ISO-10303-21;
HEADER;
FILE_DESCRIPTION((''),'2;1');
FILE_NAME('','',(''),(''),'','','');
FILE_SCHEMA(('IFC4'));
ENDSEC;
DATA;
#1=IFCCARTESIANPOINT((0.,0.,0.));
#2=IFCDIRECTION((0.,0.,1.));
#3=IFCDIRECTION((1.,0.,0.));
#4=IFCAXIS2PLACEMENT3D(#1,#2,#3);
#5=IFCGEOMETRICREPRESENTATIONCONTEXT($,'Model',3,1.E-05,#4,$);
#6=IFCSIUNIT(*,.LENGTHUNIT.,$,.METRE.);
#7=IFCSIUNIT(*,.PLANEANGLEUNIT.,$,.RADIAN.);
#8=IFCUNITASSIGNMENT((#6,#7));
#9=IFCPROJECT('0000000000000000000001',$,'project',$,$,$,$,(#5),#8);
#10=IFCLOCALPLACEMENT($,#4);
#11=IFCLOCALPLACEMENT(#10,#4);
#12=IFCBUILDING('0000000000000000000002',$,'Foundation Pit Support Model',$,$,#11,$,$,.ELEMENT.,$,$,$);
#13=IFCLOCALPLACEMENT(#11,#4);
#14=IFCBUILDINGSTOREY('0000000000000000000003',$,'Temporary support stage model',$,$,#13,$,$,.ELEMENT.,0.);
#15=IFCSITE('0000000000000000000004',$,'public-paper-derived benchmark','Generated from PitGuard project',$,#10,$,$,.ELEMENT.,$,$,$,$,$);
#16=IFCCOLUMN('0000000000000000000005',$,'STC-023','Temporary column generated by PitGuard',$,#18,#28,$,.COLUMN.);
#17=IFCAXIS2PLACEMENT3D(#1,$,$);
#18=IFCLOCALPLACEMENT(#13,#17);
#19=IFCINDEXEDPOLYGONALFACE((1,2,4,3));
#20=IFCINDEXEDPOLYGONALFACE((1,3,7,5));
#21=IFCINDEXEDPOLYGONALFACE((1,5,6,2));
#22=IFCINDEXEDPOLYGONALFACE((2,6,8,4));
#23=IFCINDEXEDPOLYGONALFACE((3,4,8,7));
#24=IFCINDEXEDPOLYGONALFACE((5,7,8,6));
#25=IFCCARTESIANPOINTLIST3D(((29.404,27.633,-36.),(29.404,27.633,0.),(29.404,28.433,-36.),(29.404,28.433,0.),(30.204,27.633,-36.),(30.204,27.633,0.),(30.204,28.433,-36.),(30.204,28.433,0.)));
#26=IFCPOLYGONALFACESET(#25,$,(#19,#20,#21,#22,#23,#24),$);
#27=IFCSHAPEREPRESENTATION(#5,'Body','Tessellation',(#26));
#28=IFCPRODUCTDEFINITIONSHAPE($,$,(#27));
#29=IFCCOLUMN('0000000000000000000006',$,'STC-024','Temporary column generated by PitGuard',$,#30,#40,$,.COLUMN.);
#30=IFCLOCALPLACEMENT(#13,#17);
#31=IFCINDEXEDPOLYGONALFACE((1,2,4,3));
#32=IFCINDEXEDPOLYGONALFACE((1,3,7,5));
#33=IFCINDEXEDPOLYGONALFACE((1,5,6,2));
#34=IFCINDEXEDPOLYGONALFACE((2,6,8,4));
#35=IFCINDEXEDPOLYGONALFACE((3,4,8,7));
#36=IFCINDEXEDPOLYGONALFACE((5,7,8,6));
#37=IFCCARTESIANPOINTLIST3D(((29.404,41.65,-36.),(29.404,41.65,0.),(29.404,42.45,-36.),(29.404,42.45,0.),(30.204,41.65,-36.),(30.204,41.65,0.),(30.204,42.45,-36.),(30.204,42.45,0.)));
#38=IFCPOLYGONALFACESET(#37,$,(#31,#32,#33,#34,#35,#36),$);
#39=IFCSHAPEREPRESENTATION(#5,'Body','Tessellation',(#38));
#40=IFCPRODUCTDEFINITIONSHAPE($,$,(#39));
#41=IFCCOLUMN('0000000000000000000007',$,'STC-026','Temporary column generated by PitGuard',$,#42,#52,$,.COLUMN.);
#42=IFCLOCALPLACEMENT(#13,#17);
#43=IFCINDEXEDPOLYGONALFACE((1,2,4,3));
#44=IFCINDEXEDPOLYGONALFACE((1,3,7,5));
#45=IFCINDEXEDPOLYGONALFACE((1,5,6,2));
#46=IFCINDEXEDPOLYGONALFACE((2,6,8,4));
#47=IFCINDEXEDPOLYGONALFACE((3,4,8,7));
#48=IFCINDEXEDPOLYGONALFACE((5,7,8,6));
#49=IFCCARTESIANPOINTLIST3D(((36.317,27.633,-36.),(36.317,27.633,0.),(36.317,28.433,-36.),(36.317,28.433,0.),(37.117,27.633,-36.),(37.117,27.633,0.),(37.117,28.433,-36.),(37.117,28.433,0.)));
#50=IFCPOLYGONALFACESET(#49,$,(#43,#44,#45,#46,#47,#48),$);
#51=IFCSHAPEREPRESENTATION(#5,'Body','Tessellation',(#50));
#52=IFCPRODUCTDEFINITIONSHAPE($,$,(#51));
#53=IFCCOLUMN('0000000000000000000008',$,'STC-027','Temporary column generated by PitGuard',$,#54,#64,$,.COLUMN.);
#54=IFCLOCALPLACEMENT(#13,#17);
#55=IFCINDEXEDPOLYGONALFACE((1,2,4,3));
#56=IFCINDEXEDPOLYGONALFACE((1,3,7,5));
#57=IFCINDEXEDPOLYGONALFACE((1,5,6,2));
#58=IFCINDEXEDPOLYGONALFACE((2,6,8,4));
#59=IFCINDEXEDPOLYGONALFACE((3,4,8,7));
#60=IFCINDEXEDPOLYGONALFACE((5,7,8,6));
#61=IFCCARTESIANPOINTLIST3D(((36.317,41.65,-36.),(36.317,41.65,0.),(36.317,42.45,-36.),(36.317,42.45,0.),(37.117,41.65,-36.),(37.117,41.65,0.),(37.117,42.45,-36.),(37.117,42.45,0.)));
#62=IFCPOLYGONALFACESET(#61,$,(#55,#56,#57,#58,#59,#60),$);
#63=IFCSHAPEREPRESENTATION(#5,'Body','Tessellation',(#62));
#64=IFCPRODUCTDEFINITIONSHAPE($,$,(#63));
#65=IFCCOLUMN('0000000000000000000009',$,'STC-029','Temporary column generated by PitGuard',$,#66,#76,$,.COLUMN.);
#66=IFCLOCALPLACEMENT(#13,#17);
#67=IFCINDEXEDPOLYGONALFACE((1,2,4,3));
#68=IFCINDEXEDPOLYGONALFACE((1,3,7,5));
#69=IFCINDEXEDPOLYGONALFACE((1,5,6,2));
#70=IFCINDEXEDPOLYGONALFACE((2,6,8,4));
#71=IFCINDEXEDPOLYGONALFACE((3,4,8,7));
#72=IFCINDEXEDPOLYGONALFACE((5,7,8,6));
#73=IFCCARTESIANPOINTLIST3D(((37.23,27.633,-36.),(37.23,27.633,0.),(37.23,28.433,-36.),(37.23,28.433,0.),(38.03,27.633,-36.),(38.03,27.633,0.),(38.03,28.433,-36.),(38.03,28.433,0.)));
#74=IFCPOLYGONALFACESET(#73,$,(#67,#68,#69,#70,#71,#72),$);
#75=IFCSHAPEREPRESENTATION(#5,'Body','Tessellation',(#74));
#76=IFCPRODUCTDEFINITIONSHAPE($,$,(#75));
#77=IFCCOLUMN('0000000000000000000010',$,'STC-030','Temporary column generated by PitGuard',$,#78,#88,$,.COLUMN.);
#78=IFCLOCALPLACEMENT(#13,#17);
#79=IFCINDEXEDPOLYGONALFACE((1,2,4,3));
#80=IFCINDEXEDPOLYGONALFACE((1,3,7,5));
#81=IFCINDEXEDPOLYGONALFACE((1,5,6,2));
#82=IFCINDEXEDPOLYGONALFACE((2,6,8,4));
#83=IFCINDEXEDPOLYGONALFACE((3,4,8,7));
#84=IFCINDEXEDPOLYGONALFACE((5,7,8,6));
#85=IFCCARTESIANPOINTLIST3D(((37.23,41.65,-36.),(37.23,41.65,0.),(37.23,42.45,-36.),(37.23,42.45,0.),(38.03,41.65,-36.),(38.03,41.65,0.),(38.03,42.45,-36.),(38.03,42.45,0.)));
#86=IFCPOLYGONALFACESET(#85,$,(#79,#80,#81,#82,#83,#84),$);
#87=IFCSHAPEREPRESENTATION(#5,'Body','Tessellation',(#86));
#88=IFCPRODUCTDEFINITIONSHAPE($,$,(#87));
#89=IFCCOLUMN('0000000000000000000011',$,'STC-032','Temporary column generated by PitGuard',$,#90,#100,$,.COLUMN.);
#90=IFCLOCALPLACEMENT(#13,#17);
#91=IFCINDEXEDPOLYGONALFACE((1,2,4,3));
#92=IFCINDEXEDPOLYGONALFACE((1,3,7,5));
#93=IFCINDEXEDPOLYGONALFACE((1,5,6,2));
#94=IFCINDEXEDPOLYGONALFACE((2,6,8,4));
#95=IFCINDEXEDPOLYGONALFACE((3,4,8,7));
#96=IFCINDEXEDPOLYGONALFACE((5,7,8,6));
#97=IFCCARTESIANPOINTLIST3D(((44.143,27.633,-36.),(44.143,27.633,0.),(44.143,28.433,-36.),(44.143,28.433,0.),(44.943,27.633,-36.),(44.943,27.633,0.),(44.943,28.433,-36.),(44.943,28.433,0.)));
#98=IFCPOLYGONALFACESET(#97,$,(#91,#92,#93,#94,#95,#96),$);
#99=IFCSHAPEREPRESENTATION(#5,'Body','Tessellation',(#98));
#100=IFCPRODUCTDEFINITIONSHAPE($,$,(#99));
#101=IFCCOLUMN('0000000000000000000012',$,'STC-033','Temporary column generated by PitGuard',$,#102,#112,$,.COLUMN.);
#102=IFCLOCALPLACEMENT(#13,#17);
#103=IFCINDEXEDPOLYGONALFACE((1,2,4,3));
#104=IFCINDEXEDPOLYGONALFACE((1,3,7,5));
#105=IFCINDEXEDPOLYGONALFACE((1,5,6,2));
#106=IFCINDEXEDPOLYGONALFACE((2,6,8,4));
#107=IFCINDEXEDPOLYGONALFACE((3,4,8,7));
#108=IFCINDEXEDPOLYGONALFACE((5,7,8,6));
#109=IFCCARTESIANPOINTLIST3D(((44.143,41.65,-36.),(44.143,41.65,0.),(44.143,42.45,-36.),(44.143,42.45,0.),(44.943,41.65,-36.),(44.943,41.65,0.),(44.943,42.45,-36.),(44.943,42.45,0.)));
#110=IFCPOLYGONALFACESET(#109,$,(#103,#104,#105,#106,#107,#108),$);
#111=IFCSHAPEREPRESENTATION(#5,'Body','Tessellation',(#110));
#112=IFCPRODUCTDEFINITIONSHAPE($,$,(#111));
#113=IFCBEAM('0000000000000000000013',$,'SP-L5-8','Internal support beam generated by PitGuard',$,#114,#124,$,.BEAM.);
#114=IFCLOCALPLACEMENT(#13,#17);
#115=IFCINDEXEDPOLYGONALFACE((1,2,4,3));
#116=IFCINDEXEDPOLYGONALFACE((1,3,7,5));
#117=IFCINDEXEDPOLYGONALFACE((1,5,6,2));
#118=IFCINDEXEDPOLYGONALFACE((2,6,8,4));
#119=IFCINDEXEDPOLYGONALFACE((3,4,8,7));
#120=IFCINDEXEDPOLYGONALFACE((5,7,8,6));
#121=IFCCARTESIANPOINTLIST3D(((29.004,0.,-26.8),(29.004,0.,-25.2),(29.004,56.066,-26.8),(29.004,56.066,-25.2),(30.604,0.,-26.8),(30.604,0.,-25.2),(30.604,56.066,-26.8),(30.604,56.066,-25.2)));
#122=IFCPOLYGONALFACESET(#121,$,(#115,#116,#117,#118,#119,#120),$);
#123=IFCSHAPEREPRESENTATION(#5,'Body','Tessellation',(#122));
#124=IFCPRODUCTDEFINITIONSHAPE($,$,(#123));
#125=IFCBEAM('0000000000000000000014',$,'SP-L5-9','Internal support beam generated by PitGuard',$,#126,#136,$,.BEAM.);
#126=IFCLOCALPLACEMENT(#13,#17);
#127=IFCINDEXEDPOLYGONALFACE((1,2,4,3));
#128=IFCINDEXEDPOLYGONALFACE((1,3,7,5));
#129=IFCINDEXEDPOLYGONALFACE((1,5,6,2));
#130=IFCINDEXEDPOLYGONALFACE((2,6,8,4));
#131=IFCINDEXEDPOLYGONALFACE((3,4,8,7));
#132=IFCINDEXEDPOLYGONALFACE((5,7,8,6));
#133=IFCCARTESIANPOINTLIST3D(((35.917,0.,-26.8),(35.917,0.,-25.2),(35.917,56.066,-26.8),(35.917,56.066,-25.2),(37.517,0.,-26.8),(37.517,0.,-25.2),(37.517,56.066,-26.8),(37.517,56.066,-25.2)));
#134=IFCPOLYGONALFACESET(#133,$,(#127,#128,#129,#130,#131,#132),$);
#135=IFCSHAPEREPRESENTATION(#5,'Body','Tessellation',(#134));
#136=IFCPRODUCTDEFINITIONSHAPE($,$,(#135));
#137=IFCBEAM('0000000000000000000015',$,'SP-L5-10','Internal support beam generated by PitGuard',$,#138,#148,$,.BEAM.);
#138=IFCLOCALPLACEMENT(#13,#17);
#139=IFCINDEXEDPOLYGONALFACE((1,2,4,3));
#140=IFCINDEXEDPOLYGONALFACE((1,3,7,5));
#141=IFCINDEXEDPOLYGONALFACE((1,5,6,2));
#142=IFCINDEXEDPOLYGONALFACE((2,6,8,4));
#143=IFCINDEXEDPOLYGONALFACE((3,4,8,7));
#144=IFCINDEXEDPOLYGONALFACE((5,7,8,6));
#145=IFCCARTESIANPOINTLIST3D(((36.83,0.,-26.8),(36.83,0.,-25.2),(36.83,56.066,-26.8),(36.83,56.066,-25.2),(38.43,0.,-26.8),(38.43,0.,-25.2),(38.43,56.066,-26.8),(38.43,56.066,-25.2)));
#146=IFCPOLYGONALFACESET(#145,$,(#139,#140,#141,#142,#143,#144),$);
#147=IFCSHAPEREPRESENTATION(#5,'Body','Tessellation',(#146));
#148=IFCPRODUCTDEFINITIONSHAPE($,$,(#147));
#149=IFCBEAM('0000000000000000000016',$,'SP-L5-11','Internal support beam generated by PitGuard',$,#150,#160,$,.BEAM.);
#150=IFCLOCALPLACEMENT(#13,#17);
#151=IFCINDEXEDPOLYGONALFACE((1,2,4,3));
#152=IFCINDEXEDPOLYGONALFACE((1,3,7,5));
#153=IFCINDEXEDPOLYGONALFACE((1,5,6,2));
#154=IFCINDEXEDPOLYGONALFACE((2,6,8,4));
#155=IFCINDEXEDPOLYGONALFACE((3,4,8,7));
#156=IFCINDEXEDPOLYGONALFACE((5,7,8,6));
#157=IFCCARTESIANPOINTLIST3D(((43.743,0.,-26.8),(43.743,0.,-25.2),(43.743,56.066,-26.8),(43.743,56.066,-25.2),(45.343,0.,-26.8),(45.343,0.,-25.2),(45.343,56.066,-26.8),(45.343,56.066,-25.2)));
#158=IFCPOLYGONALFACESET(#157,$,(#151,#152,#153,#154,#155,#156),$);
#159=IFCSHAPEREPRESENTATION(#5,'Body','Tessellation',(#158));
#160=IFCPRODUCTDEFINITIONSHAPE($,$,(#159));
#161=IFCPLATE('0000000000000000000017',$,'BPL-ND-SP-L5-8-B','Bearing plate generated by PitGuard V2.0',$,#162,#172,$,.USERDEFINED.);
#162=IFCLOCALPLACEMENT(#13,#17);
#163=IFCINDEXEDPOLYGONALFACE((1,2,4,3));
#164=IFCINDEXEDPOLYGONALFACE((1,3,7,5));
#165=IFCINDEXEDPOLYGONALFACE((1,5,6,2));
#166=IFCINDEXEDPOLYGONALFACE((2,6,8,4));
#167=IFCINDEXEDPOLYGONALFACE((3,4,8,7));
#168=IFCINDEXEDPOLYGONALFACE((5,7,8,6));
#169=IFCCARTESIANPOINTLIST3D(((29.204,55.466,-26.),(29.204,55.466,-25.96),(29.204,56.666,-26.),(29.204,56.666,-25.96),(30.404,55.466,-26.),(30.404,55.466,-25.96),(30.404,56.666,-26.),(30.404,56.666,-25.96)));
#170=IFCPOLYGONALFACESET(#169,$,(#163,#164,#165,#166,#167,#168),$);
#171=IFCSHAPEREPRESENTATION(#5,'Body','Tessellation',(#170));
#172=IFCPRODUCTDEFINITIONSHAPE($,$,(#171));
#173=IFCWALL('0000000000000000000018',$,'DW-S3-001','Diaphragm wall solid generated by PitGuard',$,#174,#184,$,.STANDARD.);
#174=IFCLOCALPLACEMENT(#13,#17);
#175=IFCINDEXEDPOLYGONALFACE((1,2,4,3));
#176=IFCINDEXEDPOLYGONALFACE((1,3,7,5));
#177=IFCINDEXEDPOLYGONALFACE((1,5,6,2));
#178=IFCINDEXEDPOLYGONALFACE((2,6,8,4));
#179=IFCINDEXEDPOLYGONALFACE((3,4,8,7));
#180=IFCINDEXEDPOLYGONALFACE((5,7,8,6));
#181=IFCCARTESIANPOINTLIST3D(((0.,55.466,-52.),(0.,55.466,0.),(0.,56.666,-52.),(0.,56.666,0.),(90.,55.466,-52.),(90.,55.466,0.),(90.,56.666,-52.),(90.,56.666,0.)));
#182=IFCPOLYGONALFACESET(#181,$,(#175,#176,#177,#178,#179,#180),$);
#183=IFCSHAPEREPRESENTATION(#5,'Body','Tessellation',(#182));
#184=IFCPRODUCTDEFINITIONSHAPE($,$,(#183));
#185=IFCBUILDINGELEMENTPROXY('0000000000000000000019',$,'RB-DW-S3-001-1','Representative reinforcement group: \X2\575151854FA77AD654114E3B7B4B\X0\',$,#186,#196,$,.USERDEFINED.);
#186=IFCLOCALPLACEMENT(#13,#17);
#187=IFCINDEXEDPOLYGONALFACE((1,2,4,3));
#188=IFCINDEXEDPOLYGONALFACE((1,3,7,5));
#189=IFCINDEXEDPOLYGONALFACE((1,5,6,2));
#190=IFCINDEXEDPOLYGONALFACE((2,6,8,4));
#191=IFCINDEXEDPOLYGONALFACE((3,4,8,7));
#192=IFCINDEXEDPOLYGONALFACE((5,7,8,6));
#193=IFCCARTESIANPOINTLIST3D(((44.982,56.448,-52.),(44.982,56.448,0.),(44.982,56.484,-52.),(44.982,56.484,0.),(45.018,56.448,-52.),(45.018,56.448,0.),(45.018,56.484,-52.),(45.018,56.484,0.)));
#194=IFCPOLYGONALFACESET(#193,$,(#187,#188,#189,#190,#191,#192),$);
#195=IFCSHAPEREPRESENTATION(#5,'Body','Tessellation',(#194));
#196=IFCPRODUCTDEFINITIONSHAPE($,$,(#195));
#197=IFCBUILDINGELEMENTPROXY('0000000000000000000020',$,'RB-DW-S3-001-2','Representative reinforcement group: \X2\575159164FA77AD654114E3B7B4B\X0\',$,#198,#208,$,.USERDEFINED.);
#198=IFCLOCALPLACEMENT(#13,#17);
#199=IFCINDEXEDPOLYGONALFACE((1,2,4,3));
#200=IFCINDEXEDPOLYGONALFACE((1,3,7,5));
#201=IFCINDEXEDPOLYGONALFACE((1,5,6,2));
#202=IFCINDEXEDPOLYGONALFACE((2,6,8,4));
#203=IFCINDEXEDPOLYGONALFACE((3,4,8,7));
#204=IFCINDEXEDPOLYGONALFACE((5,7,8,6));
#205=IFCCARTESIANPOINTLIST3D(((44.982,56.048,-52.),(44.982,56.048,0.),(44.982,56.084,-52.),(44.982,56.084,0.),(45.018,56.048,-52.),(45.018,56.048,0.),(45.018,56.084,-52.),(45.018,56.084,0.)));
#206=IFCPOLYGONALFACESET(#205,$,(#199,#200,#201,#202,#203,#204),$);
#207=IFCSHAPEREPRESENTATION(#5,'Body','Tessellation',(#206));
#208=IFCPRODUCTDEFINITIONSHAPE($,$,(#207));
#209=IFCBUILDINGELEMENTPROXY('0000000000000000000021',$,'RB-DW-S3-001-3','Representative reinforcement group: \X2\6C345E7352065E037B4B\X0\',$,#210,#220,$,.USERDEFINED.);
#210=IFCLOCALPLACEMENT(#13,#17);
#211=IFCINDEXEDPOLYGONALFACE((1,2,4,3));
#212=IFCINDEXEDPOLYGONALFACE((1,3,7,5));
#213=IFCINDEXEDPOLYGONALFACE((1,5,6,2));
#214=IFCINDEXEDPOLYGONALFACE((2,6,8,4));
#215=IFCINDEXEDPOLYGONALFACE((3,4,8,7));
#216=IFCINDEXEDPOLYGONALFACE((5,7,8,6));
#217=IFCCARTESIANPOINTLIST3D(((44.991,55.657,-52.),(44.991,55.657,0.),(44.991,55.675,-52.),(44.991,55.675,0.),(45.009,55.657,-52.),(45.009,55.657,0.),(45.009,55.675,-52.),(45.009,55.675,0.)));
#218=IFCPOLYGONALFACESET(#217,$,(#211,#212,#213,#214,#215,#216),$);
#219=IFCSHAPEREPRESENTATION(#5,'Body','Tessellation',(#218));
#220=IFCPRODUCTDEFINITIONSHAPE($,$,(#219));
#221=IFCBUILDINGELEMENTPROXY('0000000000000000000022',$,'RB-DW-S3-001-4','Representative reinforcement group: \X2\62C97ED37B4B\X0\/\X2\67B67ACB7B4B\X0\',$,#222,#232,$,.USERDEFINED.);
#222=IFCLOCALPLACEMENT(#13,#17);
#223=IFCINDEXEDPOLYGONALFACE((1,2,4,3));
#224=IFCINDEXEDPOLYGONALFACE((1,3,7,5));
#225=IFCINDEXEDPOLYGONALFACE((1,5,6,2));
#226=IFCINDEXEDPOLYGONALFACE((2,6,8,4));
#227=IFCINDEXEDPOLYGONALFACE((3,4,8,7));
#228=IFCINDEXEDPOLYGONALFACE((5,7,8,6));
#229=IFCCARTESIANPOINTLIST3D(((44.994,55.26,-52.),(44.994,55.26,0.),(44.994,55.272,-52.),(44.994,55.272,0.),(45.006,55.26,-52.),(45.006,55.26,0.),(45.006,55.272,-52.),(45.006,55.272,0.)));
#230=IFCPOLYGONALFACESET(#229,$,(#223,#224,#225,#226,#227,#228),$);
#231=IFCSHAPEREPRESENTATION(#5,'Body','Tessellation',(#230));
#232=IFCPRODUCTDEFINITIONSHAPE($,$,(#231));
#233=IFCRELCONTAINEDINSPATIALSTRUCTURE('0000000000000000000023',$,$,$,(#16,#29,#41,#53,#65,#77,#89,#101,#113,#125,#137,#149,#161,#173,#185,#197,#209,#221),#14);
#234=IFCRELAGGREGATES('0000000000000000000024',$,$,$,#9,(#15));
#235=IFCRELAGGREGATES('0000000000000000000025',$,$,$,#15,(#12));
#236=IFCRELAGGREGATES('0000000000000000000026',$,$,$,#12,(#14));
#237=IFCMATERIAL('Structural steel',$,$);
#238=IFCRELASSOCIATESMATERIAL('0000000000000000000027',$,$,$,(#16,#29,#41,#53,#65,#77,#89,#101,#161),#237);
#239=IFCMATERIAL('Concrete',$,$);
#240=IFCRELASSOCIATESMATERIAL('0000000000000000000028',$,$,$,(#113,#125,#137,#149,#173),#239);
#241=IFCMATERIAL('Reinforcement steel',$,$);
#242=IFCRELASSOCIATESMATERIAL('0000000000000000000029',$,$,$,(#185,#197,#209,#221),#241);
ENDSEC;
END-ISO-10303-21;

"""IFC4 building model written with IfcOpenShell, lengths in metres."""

from ifc_helpers import new_model, si_unit, frame, origin_with_axes, origin_2d, place, context, project, spatial, rectangle, extrude, material, element, save


model = new_model("IFC4")

# Units and contexts
model_context = context("Model", 3, precision=1e-05, world=origin_with_axes())
ifc_project = project(units=[si_unit("LENGTHUNIT", "METRE"), si_unit("PLANEANGLEUNIT", "RADIAN")], contexts=[model_context])

# Site, building, storey
site_placement = place(None, origin_with_axes())
site = spatial("IfcSite", under=ifc_project, at=site_placement, Name="public-paper-derived benchmark", Description="Generated from PitGuard project", CompositionType="ELEMENT")
building_placement = place(site_placement, origin_with_axes())
building = spatial("IfcBuilding", under=site, at=building_placement, Name="Foundation Pit Support Model", CompositionType="ELEMENT")
storey_placement = place(building_placement, origin_with_axes())
storey = spatial("IfcBuildingStorey", under=building, at=storey_placement, Name="Temporary support stage model", CompositionType="ELEMENT", Elevation=0.0)

# Columns
ifc_material_1 = material(Name="Structural steel")
for number, where, z_axis, x_axis, name in (
    (1, (29.804, 28.033, -36.0), (0.0, 0.0, 1.0), (1.0, 0.0, 0.0), "STC-023"),
    (2, (29.804, 42.05, -36.0), (0.0, 0.0, 1.0), (1.0, 0.0, 0.0), "STC-024"),
    (3, (36.717, 28.033, -36.0), (0.0, 0.0, 1.0), (1.0, 0.0, 0.0), "STC-026"),
    (4, (36.717, 42.05, -36.0), (0.0, 0.0, 1.0), (1.0, 0.0, 0.0), "STC-027"),
    (5, (37.63, 28.033, -36.0), (0.0, 0.0, 1.0), (1.0, 0.0, 0.0), "STC-029"),
    (6, (37.63, 42.05, -36.0), (0.0, 0.0, 1.0), (1.0, 0.0, 0.0), "STC-030"),
    (7, (44.543, 28.033, -36.0), (0.0, 0.0, 1.0), (1.0, 0.0, 0.0), "STC-032"),
    (8, (44.543, 42.05, -36.0), (0.0, 0.0, 1.0), (1.0, 0.0, 0.0), "STC-033"),
):
    element("IfcColumn", number, at=place(storey_placement, frame(where, z_axis=z_axis, x_axis=x_axis)), inside=storey, material=ifc_material_1, Name=name, Description="Temporary column generated by PitGuard", PredefinedType="COLUMN", context=model_context, shape_type="SweptSolid", body=[
        extrude(rectangle(XDim=0.8, YDim=0.8, at=origin_2d()), origin_with_axes(), (0.0, 0.0, 1.0), 36.0),
    ])

# Beams
ifc_material_2 = material(Name="Concrete")
for number, where, z_axis, x_axis, name in (
    (9, (29.804, 28.033, -26.8), (0.0, 0.0, 1.0), (0.0, 1.0, 0.0), "SP-L5-8"),
    (10, (36.717, 28.033, -26.8), (0.0, 0.0, 1.0), (0.0, 1.0, 0.0), "SP-L5-9"),
    (11, (37.63, 28.033, -26.8), (0.0, 0.0, 1.0), (0.0, 1.0, 0.0), "SP-L5-10"),
    (12, (44.543, 28.033, -26.8), (0.0, 0.0, 1.0), (0.0, 1.0, 0.0), "SP-L5-11"),
):
    element("IfcBeam", number, at=place(storey_placement, frame(where, z_axis=z_axis, x_axis=x_axis)), inside=storey, material=ifc_material_2, Name=name, Description="Internal support beam generated by PitGuard", PredefinedType="BEAM", context=model_context, shape_type="SweptSolid", body=[
        extrude(rectangle(XDim=56.066, YDim=1.6, at=origin_2d()), origin_with_axes(), (0.0, 0.0, 1.0), 1.6),
    ])

# Plate
plate_placement = place(storey_placement, frame((29.804, 56.066, -26.0), z_axis=(0.0, 0.0, 1.0), x_axis=(1.0, 0.0, 0.0)))
element("IfcPlate", 13, at=plate_placement, inside=storey, material=ifc_material_1, Name="BPL-ND-SP-L5-8-B", Description="Bearing plate generated by PitGuard V2.0", PredefinedType="USERDEFINED", context=model_context, shape_type="SweptSolid", body=[
    extrude(rectangle(XDim=1.2, YDim=1.2, at=origin_2d()), origin_with_axes(), (0.0, 0.0, 1.0), 0.04),
])

# Wall
wall_placement = place(storey_placement, frame((45.0, 56.066, -52.0), z_axis=(0.0, 0.0, 1.0), x_axis=(-1.0, 0.0, 0.0)))
element("IfcWall", 14, at=wall_placement, inside=storey, material=ifc_material_2, Name="DW-S3-001", Description="Diaphragm wall solid generated by PitGuard", PredefinedType="STANDARD", context=model_context, shape_type="SweptSolid", body=[
    extrude(rectangle(XDim=90.0, YDim=1.2, at=origin_2d()), origin_with_axes(), (0.0, 0.0, 1.0), 52.0),
])

# Building element proxies
ifc_material_3 = material(Name="Reinforcement steel")
for number, where, z_axis, x_axis, name, description in (
    (15, (45.0, 56.466, -52.0), (0.0, 0.0, 1.0), (1.0, 0.0, 0.0), "RB-DW-S3-001-1", "Representative reinforcement group: 坑内侧竖向主筋"),
    (16, (45.0, 56.066, -52.0), (0.0, 0.0, 1.0), (1.0, 0.0, 0.0), "RB-DW-S3-001-2", "Representative reinforcement group: 坑外侧竖向主筋"),
):
    element("IfcBuildingElementProxy", number, at=place(storey_placement, frame(where, z_axis=z_axis, x_axis=x_axis)), inside=storey, material=ifc_material_3, Name=name, Description=description, PredefinedType="USERDEFINED", context=model_context, shape_type="SweptSolid", body=[
        extrude(rectangle(XDim=0.036, YDim=0.036, at=origin_2d()), origin_with_axes(), (0.0, 0.0, 1.0), 52.0),
    ])
proxy_1_placement = place(storey_placement, frame((45.0, 55.666, -52.0), z_axis=(0.0, 0.0, 1.0), x_axis=(1.0, 0.0, 0.0)))
element("IfcBuildingElementProxy", 17, at=proxy_1_placement, inside=storey, material=ifc_material_3, Name="RB-DW-S3-001-3", Description="Representative reinforcement group: 水平分布筋", PredefinedType="USERDEFINED", context=model_context, shape_type="SweptSolid", body=[
    extrude(rectangle(XDim=0.018, YDim=0.018, at=origin_2d()), origin_with_axes(), (0.0, 0.0, 1.0), 52.0),
])
proxy_2_placement = place(storey_placement, frame((45.0, 55.266, -52.0), z_axis=(0.0, 0.0, 1.0), x_axis=(1.0, 0.0, 0.0)))
element("IfcBuildingElementProxy", 18, at=proxy_2_placement, inside=storey, material=ifc_material_3, Name="RB-DW-S3-001-4", Description="Representative reinforcement group: 拉结筋/架立筋", PredefinedType="USERDEFINED", context=model_context, shape_type="SweptSolid", body=[
    extrude(rectangle(XDim=0.012, YDim=0.012, at=origin_2d()), origin_with_axes(), (0.0, 0.0, 1.0), 52.0),
])

save(model, "model.ifc")
